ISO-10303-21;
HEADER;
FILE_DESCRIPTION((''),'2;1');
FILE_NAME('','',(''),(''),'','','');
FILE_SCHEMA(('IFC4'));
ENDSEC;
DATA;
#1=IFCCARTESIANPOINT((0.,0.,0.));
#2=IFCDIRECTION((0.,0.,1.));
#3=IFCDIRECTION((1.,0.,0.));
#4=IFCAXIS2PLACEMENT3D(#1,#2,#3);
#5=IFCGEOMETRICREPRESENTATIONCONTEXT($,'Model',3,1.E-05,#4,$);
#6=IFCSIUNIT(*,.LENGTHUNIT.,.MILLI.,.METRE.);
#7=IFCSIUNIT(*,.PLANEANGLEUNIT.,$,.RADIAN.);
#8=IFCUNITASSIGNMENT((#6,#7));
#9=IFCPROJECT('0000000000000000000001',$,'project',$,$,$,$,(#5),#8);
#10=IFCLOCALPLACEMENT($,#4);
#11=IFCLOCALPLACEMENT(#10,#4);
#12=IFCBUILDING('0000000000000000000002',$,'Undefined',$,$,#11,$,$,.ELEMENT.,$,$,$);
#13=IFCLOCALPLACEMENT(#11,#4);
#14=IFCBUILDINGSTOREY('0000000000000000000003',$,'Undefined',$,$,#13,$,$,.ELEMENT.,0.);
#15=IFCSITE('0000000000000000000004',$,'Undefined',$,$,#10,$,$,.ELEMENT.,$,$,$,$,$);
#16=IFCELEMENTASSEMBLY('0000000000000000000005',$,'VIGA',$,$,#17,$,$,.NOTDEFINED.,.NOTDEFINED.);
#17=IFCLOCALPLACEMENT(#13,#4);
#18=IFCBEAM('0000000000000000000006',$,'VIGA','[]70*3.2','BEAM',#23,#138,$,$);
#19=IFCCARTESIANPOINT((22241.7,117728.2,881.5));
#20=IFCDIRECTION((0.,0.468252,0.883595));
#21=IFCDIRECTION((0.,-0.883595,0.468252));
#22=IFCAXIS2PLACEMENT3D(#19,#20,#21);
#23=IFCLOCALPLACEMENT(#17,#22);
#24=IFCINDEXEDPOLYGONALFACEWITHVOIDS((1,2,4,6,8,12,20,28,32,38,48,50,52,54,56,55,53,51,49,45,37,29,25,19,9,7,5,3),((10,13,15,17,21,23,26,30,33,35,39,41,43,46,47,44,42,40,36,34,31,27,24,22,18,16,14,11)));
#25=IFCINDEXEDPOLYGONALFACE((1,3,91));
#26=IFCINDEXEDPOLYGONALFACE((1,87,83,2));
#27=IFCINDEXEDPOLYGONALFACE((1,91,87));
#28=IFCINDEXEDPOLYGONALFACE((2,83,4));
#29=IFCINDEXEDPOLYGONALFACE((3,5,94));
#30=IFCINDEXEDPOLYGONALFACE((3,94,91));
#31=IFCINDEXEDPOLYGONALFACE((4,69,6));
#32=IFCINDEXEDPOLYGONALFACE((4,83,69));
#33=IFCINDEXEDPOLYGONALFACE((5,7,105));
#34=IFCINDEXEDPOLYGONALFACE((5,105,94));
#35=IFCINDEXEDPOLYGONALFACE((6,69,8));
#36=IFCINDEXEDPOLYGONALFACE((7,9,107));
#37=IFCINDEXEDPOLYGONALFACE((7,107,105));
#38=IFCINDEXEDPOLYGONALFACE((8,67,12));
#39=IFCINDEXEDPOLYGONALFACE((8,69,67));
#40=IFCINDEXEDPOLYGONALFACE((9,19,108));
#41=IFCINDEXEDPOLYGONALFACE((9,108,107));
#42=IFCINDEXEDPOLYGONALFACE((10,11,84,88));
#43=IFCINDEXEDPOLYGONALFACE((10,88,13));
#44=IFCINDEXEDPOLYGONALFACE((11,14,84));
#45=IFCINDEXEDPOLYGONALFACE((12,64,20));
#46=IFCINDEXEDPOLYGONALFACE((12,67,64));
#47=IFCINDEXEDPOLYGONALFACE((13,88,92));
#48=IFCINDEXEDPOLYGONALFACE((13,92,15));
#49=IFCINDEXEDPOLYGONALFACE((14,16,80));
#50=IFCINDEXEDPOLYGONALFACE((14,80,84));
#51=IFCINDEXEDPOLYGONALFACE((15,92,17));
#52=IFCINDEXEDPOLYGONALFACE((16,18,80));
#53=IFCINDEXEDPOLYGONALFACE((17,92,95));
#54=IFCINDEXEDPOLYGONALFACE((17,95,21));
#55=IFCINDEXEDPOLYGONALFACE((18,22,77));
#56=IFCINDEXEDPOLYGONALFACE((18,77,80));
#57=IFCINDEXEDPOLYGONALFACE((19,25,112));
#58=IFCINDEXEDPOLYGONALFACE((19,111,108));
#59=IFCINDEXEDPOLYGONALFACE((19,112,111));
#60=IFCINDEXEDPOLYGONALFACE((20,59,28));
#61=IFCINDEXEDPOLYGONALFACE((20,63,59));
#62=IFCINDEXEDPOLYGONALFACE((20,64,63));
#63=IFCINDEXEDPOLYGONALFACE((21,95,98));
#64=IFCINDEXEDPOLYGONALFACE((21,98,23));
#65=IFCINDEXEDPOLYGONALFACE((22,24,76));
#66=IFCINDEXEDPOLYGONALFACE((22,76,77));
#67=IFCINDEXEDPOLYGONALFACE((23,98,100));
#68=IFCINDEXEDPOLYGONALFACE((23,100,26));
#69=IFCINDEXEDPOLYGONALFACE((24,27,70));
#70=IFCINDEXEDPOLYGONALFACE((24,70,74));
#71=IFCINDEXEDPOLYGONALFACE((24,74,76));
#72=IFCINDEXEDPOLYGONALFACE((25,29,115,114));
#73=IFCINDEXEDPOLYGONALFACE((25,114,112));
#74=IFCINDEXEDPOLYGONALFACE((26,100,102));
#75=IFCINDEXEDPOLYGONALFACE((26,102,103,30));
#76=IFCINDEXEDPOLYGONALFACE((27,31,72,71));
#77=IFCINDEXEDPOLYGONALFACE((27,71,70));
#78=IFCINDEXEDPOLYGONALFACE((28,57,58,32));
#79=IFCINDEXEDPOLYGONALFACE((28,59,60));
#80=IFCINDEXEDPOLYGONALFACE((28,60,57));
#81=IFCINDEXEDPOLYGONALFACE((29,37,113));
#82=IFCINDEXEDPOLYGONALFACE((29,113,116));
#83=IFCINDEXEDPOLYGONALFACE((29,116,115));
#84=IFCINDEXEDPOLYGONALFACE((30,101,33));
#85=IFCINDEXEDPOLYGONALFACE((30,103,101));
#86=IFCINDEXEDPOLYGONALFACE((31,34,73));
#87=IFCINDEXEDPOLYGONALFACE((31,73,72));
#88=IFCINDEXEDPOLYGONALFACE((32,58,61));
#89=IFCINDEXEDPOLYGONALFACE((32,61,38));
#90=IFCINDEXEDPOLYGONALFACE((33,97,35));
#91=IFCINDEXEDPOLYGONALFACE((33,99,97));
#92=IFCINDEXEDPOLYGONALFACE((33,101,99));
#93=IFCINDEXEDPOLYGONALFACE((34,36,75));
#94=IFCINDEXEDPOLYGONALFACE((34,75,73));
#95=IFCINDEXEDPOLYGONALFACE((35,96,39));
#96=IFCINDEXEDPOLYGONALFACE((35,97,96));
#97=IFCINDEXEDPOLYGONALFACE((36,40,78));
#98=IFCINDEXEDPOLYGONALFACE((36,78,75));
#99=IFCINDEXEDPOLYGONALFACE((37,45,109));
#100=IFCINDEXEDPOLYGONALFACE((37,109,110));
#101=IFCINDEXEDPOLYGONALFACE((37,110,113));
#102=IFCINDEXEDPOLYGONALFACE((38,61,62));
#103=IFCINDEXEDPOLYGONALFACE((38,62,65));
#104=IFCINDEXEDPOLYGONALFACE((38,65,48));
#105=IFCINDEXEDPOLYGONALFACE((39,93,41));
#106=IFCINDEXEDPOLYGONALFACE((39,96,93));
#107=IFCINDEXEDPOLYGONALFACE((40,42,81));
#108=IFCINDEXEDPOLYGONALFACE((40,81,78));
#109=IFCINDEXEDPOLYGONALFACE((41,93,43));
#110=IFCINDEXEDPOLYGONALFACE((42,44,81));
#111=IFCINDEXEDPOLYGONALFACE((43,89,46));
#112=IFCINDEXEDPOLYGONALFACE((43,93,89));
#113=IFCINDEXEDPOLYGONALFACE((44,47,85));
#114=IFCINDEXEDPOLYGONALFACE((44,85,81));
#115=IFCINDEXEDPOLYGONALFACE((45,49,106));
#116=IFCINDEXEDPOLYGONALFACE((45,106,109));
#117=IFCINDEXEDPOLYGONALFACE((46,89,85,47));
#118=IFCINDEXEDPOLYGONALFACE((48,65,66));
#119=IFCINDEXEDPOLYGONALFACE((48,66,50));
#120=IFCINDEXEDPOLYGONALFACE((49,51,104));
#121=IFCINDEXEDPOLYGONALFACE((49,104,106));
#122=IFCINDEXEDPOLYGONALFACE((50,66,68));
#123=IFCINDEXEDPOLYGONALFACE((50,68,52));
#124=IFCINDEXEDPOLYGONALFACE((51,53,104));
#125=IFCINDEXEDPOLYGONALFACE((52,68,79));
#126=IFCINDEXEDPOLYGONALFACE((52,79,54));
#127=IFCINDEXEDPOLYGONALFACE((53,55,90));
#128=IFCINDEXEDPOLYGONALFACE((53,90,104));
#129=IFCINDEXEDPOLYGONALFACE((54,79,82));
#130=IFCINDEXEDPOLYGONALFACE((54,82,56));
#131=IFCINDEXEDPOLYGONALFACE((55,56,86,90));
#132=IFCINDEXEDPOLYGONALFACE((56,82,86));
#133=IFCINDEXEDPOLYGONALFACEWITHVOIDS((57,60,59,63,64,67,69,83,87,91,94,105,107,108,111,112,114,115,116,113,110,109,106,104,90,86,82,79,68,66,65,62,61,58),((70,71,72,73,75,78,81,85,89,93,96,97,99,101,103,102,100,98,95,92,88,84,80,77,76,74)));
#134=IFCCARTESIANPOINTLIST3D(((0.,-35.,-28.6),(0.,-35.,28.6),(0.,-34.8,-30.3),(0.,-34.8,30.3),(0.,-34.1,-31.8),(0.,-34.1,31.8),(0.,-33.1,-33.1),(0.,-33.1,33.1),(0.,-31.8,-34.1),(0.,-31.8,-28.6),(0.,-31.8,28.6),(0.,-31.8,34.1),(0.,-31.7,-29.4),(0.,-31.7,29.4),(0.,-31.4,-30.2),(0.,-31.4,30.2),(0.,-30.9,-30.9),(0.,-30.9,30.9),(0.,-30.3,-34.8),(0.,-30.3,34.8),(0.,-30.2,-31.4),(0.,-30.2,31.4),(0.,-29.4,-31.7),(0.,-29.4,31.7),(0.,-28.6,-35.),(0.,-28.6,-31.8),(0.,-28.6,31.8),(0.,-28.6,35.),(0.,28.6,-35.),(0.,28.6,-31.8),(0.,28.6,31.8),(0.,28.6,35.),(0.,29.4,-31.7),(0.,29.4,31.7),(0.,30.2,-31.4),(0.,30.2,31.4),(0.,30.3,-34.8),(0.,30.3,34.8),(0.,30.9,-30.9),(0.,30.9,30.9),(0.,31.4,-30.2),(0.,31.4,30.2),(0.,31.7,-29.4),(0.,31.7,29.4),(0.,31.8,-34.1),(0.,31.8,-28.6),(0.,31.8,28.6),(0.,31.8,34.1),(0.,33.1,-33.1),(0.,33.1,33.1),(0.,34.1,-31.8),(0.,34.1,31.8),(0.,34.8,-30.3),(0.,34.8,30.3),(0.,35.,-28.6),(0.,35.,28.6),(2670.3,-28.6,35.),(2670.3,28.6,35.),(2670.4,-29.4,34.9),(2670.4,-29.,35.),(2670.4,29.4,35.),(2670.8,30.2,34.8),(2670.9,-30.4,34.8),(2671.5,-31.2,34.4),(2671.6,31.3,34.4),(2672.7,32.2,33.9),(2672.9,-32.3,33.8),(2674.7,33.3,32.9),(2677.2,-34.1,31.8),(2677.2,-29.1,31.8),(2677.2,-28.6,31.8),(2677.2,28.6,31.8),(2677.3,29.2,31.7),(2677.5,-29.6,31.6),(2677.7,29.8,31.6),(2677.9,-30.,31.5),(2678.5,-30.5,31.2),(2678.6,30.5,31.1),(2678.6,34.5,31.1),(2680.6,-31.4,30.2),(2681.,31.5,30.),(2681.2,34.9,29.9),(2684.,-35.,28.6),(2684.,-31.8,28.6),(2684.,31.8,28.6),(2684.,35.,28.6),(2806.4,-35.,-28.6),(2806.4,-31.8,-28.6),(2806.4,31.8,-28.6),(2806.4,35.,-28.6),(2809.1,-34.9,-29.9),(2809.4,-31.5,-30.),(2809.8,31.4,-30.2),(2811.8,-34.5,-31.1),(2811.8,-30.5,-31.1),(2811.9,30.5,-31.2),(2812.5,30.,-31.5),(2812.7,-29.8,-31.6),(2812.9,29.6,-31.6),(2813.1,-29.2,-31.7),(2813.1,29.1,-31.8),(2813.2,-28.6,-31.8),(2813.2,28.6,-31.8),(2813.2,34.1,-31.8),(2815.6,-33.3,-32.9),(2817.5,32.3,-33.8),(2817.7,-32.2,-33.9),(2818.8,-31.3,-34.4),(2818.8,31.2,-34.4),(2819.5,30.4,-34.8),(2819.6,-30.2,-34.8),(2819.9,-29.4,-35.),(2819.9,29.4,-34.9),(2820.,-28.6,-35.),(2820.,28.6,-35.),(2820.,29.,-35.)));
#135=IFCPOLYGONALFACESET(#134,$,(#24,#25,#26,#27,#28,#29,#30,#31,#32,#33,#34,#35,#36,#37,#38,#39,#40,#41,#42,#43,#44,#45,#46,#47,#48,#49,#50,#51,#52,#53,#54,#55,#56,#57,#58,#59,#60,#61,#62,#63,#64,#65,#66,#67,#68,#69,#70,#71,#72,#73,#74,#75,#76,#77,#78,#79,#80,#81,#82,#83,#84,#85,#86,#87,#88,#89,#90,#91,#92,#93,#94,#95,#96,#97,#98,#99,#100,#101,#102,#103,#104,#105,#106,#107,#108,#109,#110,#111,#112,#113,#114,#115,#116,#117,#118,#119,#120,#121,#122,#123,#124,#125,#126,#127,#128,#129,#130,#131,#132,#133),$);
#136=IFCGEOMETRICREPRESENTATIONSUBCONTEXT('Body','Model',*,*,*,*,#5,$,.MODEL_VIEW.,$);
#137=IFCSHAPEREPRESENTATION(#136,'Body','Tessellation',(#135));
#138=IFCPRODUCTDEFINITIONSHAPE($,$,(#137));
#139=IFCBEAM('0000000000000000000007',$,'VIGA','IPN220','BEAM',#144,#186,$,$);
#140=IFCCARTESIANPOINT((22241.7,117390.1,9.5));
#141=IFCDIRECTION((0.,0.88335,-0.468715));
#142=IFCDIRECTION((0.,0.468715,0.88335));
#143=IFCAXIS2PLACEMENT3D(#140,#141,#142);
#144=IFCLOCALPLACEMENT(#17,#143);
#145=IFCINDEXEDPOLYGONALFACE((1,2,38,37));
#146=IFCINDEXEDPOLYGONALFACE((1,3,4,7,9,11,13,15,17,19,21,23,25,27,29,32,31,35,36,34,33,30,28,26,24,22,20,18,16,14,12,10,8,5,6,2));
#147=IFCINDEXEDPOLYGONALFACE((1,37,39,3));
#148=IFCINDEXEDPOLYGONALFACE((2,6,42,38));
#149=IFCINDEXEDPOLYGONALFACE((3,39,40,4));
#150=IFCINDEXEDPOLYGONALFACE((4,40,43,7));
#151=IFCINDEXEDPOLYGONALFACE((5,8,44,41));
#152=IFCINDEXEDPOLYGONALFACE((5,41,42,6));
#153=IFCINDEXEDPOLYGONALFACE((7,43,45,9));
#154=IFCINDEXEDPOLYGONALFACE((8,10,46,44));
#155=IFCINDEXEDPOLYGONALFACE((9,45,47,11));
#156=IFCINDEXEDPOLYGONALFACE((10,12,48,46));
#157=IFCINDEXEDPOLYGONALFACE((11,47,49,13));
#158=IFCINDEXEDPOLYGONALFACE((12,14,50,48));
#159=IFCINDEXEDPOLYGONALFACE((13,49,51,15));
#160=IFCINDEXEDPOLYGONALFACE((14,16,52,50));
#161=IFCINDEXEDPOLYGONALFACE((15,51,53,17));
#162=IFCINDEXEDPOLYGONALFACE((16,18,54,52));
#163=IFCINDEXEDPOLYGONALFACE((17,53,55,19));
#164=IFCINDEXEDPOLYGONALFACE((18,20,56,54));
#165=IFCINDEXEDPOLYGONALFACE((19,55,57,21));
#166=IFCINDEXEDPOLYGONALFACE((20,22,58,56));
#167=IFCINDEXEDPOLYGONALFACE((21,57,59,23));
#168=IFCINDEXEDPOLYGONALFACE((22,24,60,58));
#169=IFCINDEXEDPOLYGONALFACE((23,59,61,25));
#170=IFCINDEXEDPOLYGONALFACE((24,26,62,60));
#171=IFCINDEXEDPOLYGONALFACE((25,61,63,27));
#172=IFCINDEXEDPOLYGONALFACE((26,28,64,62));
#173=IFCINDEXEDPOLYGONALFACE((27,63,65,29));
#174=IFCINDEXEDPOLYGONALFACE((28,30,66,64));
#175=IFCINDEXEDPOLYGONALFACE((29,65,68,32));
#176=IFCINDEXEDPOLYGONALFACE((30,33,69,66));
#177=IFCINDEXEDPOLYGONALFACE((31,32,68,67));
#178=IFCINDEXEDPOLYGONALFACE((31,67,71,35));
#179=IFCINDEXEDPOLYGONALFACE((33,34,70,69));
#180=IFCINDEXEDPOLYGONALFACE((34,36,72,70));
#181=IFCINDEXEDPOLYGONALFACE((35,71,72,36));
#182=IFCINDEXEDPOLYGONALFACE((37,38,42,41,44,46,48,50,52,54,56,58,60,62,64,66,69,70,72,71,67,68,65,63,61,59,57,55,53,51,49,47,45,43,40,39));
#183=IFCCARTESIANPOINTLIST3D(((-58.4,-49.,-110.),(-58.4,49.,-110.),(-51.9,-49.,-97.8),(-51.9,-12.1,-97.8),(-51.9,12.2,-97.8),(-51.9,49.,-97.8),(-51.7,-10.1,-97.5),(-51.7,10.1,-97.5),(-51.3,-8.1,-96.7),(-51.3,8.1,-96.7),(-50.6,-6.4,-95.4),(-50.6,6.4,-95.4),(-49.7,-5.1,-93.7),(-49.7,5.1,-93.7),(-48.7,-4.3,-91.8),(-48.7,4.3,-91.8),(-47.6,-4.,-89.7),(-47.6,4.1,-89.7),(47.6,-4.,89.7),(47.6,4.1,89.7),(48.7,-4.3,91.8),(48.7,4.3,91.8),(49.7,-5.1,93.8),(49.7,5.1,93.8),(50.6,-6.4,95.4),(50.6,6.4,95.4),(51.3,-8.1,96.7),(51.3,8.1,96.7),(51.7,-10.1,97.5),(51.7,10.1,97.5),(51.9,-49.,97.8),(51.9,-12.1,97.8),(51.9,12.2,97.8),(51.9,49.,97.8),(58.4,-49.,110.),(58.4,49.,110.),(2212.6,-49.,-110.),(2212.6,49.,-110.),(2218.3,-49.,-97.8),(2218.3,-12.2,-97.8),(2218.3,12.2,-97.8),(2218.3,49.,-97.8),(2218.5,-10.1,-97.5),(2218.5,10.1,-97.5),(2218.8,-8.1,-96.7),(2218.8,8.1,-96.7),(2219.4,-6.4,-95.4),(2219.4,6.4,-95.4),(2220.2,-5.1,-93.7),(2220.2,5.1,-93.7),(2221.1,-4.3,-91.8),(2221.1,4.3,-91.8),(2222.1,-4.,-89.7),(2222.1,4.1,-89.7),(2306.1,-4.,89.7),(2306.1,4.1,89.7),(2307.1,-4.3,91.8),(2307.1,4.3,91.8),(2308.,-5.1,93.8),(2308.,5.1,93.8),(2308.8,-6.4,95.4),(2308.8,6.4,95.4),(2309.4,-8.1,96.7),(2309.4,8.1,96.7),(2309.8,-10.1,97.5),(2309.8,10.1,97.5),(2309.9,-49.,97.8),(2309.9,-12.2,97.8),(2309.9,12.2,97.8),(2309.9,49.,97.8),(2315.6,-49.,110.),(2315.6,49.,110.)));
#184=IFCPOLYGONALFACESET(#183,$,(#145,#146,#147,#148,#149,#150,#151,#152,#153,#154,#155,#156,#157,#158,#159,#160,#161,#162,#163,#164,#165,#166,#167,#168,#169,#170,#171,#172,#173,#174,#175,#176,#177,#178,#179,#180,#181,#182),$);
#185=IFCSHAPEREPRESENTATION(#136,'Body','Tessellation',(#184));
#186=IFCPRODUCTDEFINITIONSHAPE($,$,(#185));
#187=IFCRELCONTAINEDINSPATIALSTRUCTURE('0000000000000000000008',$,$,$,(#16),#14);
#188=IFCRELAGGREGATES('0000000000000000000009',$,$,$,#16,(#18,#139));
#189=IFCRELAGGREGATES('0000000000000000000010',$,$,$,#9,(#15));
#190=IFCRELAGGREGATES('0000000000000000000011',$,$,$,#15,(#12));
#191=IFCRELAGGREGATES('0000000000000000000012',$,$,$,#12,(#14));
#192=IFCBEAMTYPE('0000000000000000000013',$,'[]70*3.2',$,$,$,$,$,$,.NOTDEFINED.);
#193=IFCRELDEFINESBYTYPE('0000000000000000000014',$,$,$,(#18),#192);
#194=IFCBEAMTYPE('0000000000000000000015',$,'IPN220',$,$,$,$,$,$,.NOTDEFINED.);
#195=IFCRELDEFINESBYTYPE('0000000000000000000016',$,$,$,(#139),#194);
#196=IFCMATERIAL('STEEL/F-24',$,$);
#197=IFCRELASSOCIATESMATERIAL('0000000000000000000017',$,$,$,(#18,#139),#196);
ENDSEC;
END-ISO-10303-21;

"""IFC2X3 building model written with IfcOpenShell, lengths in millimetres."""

from ifc_helpers import new_model, si_unit, frame, origin_with_axes, origin_2d_with_axis, place, context, subcontext, project, spatial, hollow_rectangle, i_section, extrude, clip, halfspace, material, type_object, element, aggregate, save


model = new_model("IFC2X3")

# Units and contexts
model_context = context("Model", 3, precision=1e-05, world=origin_with_axes())
body_context = subcontext(model_context, "Body", "Model", "MODEL_VIEW")
ifc_project = project(units=[si_unit("LENGTHUNIT", "METRE", prefix="MILLI"), si_unit("PLANEANGLEUNIT", "RADIAN")], contexts=[model_context])

# Site, building, storey
site_placement = place(None, origin_with_axes())
site = spatial("IfcSite", under=ifc_project, at=site_placement, Name="Undefined", CompositionType="ELEMENT")
building_placement = place(site_placement, origin_with_axes())
building = spatial("IfcBuilding", under=site, at=building_placement, Name="Undefined", CompositionType="ELEMENT")
storey_placement = place(building_placement, origin_with_axes())
storey = spatial("IfcBuildingStorey", under=building, at=storey_placement, Name="Undefined", CompositionType="ELEMENT", Elevation=0.0)

# Element assembly, beams
assembly_1_placement = place(storey_placement, origin_with_axes())
assembly_1 = element("IfcElementAssembly", 1, at=assembly_1_placement, inside=storey, Name="VIGA", AssemblyPlace="NOTDEFINED", PredefinedType="NOTDEFINED")
ifc_material_1 = material(Name="STEEL/F-24")
beam_type_1 = type_object("IfcBeamType", Name="[]70*3.2", PredefinedType="NOTDEFINED")
beam_1_placement = place(assembly_1_placement, frame((22241.7, 117728.2, 881.5), z_axis=(0.0, 0.468252, 0.883595), x_axis=(0.0, -0.883595, 0.468252)))
beam_1 = element("IfcBeam", 2, at=beam_1_placement, type_object=beam_type_1, material=ifc_material_1, Name="VIGA", Description="[]70*3.2", ObjectType="BEAM", context=body_context, shape_type="Clipping", body=[
    clip(extrude(hollow_rectangle(XDim=70.0, YDim=70.0, WallThickness=3.2, InnerFilletRadius=3.2, OuterFilletRadius=6.4, at=origin_2d_with_axis()), frame((2850.0, 0.0, 0.0), z_axis=(-1.0, 0.0, 0.0), x_axis=(0.0, -1.0, 0.0)), (0.0, 0.0, 1.0), 2850.0), halfspace(frame((2745.2, 0.0, 0.0), z_axis=(-0.423531, 0.0, -0.905881), x_axis=(0.905881, 0.0, -0.423531)), True)),
])
beam_type_2 = type_object("IfcBeamType", Name="IPN220", PredefinedType="NOTDEFINED")
beam_2_placement = place(assembly_1_placement, frame((22241.7, 117390.1, 9.5), z_axis=(0.0, 0.88335, -0.468715), x_axis=(0.0, 0.468715, 0.88335)))
beam_2 = element("IfcBeam", 3, at=beam_2_placement, type_object=beam_type_2, material=ifc_material_1, Name="VIGA", Description="IPN220", ObjectType="BEAM", context=body_context, shape_type="Clipping", body=[
    clip(clip(extrude(i_section(OverallWidth=98.0, OverallDepth=220.0, WebThickness=8.1, FlangeThickness=12.2, FilletRadius=8.1, at=origin_2d_with_axis()), frame((2385.9, 0.0, 0.0), z_axis=(-1.0, 0.0, 0.0), x_axis=(0.0, -1.0, 0.0)), (0.0, 0.0, 1.0), 2507.7), halfspace(frame((2264.1, 0.0, 0.0), z_axis=(-0.905659, 0.0, 0.424006), x_axis=(0.424006, 0.0, 0.905659)), True)), halfspace(frame((0.0, 0.0, 0.0), z_axis=(-0.88335, 0.0, 0.468715), x_axis=(-0.468715, 0.0, -0.88335)), False)),
])

aggregate(assembly_1, [beam_1, beam_2])

save(model, "model.ifc")
